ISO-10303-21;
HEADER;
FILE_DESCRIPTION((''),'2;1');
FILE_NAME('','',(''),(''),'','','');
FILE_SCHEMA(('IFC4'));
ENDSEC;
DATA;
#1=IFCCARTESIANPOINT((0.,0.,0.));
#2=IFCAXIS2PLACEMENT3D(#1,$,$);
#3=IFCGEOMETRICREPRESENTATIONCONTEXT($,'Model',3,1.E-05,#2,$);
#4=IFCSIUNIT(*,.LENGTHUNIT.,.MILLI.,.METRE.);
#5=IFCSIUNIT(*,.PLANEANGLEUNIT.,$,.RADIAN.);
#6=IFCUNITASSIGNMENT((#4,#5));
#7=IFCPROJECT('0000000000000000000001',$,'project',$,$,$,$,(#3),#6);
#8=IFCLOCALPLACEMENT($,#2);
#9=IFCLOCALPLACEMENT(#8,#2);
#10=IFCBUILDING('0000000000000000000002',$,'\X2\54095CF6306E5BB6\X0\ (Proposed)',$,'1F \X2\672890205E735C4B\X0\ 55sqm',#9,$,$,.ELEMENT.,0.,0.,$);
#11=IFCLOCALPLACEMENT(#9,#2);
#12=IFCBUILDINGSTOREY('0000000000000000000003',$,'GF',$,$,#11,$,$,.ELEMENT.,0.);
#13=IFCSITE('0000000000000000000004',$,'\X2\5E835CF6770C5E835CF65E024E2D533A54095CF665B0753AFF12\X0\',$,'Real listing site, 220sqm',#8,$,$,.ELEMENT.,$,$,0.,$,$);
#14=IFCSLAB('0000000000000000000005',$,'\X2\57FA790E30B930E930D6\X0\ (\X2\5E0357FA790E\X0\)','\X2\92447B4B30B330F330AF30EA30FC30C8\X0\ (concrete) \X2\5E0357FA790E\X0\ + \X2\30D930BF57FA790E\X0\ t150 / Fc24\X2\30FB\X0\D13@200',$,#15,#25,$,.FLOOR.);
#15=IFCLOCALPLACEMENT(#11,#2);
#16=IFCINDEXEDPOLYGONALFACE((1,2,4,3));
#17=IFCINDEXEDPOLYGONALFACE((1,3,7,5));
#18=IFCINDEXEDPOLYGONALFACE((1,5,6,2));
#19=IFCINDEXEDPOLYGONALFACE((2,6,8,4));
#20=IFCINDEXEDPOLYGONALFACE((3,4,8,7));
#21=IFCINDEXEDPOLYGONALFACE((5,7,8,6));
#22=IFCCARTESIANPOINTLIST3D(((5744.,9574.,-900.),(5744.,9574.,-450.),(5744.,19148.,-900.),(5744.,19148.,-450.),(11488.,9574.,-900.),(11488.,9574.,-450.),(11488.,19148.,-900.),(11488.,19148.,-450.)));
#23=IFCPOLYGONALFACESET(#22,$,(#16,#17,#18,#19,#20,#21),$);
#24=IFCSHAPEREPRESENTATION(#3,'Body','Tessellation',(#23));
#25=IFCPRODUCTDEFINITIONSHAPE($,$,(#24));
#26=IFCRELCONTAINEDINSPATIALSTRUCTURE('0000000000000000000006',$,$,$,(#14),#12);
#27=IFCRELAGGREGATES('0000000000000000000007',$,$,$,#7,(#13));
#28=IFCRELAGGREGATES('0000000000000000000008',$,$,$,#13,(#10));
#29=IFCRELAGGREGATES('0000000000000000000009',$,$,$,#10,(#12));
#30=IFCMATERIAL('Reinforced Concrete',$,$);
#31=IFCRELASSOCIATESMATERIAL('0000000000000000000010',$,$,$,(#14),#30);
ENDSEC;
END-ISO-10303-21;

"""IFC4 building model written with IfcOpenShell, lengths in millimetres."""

from ifc_helpers import new_model, si_unit, frame, frame_2d, origin, place, context, project, spatial, rectangle, extrude, material, element, save


model = new_model("IFC4")

# Units and contexts
model_context = context("Model", 3, precision=1e-05, world=origin())
ifc_project = project(units=[si_unit("LENGTHUNIT", "METRE", prefix="MILLI"), si_unit("PLANEANGLEUNIT", "RADIAN")], contexts=[model_context])

# Site, building, storey
site_placement = place(None, origin())
site = spatial("IfcSite", under=ifc_project, at=site_placement, Name="広島県広島市中区吉島新町２", ObjectType="Real listing site, 220sqm", CompositionType="ELEMENT", RefElevation=0.0)
building_placement = place(site_placement, origin())
building = spatial("IfcBuilding", under=site, at=building_placement, Name="吉島の家 (Proposed)", ObjectType="1F 木造平屋 55sqm", CompositionType="ELEMENT", ElevationOfRefHeight=0.0, ElevationOfTerrain=0.0)
storey_placement = place(building_placement, origin())
storey = spatial("IfcBuildingStorey", under=building, at=storey_placement, Name="GF", CompositionType="ELEMENT", Elevation=0.0)

# Slab
ifc_material_1 = material(Name="Reinforced Concrete")
slab_1_placement = place(storey_placement, frame((2872.0, 4787.0, -450.0)))
element("IfcSlab", 1, at=slab_1_placement, inside=storey, material=ifc_material_1, Name="基礎スラブ (布基礎)", Description="鉄筋コンクリート (concrete) 布基礎 + ベタ基礎 t150 / Fc24・D13@200", PredefinedType="FLOOR", context=model_context, shape_type="SweptSolid", body=[
    extrude(rectangle(XDim=5744.0, YDim=9574.0, at=frame_2d((2872.0, 4787.0))), frame((2872.0, 4787.0, -450.0)), (0.0, 0.0, 1.0), 450.0),
])

save(model, "model.ifc")
